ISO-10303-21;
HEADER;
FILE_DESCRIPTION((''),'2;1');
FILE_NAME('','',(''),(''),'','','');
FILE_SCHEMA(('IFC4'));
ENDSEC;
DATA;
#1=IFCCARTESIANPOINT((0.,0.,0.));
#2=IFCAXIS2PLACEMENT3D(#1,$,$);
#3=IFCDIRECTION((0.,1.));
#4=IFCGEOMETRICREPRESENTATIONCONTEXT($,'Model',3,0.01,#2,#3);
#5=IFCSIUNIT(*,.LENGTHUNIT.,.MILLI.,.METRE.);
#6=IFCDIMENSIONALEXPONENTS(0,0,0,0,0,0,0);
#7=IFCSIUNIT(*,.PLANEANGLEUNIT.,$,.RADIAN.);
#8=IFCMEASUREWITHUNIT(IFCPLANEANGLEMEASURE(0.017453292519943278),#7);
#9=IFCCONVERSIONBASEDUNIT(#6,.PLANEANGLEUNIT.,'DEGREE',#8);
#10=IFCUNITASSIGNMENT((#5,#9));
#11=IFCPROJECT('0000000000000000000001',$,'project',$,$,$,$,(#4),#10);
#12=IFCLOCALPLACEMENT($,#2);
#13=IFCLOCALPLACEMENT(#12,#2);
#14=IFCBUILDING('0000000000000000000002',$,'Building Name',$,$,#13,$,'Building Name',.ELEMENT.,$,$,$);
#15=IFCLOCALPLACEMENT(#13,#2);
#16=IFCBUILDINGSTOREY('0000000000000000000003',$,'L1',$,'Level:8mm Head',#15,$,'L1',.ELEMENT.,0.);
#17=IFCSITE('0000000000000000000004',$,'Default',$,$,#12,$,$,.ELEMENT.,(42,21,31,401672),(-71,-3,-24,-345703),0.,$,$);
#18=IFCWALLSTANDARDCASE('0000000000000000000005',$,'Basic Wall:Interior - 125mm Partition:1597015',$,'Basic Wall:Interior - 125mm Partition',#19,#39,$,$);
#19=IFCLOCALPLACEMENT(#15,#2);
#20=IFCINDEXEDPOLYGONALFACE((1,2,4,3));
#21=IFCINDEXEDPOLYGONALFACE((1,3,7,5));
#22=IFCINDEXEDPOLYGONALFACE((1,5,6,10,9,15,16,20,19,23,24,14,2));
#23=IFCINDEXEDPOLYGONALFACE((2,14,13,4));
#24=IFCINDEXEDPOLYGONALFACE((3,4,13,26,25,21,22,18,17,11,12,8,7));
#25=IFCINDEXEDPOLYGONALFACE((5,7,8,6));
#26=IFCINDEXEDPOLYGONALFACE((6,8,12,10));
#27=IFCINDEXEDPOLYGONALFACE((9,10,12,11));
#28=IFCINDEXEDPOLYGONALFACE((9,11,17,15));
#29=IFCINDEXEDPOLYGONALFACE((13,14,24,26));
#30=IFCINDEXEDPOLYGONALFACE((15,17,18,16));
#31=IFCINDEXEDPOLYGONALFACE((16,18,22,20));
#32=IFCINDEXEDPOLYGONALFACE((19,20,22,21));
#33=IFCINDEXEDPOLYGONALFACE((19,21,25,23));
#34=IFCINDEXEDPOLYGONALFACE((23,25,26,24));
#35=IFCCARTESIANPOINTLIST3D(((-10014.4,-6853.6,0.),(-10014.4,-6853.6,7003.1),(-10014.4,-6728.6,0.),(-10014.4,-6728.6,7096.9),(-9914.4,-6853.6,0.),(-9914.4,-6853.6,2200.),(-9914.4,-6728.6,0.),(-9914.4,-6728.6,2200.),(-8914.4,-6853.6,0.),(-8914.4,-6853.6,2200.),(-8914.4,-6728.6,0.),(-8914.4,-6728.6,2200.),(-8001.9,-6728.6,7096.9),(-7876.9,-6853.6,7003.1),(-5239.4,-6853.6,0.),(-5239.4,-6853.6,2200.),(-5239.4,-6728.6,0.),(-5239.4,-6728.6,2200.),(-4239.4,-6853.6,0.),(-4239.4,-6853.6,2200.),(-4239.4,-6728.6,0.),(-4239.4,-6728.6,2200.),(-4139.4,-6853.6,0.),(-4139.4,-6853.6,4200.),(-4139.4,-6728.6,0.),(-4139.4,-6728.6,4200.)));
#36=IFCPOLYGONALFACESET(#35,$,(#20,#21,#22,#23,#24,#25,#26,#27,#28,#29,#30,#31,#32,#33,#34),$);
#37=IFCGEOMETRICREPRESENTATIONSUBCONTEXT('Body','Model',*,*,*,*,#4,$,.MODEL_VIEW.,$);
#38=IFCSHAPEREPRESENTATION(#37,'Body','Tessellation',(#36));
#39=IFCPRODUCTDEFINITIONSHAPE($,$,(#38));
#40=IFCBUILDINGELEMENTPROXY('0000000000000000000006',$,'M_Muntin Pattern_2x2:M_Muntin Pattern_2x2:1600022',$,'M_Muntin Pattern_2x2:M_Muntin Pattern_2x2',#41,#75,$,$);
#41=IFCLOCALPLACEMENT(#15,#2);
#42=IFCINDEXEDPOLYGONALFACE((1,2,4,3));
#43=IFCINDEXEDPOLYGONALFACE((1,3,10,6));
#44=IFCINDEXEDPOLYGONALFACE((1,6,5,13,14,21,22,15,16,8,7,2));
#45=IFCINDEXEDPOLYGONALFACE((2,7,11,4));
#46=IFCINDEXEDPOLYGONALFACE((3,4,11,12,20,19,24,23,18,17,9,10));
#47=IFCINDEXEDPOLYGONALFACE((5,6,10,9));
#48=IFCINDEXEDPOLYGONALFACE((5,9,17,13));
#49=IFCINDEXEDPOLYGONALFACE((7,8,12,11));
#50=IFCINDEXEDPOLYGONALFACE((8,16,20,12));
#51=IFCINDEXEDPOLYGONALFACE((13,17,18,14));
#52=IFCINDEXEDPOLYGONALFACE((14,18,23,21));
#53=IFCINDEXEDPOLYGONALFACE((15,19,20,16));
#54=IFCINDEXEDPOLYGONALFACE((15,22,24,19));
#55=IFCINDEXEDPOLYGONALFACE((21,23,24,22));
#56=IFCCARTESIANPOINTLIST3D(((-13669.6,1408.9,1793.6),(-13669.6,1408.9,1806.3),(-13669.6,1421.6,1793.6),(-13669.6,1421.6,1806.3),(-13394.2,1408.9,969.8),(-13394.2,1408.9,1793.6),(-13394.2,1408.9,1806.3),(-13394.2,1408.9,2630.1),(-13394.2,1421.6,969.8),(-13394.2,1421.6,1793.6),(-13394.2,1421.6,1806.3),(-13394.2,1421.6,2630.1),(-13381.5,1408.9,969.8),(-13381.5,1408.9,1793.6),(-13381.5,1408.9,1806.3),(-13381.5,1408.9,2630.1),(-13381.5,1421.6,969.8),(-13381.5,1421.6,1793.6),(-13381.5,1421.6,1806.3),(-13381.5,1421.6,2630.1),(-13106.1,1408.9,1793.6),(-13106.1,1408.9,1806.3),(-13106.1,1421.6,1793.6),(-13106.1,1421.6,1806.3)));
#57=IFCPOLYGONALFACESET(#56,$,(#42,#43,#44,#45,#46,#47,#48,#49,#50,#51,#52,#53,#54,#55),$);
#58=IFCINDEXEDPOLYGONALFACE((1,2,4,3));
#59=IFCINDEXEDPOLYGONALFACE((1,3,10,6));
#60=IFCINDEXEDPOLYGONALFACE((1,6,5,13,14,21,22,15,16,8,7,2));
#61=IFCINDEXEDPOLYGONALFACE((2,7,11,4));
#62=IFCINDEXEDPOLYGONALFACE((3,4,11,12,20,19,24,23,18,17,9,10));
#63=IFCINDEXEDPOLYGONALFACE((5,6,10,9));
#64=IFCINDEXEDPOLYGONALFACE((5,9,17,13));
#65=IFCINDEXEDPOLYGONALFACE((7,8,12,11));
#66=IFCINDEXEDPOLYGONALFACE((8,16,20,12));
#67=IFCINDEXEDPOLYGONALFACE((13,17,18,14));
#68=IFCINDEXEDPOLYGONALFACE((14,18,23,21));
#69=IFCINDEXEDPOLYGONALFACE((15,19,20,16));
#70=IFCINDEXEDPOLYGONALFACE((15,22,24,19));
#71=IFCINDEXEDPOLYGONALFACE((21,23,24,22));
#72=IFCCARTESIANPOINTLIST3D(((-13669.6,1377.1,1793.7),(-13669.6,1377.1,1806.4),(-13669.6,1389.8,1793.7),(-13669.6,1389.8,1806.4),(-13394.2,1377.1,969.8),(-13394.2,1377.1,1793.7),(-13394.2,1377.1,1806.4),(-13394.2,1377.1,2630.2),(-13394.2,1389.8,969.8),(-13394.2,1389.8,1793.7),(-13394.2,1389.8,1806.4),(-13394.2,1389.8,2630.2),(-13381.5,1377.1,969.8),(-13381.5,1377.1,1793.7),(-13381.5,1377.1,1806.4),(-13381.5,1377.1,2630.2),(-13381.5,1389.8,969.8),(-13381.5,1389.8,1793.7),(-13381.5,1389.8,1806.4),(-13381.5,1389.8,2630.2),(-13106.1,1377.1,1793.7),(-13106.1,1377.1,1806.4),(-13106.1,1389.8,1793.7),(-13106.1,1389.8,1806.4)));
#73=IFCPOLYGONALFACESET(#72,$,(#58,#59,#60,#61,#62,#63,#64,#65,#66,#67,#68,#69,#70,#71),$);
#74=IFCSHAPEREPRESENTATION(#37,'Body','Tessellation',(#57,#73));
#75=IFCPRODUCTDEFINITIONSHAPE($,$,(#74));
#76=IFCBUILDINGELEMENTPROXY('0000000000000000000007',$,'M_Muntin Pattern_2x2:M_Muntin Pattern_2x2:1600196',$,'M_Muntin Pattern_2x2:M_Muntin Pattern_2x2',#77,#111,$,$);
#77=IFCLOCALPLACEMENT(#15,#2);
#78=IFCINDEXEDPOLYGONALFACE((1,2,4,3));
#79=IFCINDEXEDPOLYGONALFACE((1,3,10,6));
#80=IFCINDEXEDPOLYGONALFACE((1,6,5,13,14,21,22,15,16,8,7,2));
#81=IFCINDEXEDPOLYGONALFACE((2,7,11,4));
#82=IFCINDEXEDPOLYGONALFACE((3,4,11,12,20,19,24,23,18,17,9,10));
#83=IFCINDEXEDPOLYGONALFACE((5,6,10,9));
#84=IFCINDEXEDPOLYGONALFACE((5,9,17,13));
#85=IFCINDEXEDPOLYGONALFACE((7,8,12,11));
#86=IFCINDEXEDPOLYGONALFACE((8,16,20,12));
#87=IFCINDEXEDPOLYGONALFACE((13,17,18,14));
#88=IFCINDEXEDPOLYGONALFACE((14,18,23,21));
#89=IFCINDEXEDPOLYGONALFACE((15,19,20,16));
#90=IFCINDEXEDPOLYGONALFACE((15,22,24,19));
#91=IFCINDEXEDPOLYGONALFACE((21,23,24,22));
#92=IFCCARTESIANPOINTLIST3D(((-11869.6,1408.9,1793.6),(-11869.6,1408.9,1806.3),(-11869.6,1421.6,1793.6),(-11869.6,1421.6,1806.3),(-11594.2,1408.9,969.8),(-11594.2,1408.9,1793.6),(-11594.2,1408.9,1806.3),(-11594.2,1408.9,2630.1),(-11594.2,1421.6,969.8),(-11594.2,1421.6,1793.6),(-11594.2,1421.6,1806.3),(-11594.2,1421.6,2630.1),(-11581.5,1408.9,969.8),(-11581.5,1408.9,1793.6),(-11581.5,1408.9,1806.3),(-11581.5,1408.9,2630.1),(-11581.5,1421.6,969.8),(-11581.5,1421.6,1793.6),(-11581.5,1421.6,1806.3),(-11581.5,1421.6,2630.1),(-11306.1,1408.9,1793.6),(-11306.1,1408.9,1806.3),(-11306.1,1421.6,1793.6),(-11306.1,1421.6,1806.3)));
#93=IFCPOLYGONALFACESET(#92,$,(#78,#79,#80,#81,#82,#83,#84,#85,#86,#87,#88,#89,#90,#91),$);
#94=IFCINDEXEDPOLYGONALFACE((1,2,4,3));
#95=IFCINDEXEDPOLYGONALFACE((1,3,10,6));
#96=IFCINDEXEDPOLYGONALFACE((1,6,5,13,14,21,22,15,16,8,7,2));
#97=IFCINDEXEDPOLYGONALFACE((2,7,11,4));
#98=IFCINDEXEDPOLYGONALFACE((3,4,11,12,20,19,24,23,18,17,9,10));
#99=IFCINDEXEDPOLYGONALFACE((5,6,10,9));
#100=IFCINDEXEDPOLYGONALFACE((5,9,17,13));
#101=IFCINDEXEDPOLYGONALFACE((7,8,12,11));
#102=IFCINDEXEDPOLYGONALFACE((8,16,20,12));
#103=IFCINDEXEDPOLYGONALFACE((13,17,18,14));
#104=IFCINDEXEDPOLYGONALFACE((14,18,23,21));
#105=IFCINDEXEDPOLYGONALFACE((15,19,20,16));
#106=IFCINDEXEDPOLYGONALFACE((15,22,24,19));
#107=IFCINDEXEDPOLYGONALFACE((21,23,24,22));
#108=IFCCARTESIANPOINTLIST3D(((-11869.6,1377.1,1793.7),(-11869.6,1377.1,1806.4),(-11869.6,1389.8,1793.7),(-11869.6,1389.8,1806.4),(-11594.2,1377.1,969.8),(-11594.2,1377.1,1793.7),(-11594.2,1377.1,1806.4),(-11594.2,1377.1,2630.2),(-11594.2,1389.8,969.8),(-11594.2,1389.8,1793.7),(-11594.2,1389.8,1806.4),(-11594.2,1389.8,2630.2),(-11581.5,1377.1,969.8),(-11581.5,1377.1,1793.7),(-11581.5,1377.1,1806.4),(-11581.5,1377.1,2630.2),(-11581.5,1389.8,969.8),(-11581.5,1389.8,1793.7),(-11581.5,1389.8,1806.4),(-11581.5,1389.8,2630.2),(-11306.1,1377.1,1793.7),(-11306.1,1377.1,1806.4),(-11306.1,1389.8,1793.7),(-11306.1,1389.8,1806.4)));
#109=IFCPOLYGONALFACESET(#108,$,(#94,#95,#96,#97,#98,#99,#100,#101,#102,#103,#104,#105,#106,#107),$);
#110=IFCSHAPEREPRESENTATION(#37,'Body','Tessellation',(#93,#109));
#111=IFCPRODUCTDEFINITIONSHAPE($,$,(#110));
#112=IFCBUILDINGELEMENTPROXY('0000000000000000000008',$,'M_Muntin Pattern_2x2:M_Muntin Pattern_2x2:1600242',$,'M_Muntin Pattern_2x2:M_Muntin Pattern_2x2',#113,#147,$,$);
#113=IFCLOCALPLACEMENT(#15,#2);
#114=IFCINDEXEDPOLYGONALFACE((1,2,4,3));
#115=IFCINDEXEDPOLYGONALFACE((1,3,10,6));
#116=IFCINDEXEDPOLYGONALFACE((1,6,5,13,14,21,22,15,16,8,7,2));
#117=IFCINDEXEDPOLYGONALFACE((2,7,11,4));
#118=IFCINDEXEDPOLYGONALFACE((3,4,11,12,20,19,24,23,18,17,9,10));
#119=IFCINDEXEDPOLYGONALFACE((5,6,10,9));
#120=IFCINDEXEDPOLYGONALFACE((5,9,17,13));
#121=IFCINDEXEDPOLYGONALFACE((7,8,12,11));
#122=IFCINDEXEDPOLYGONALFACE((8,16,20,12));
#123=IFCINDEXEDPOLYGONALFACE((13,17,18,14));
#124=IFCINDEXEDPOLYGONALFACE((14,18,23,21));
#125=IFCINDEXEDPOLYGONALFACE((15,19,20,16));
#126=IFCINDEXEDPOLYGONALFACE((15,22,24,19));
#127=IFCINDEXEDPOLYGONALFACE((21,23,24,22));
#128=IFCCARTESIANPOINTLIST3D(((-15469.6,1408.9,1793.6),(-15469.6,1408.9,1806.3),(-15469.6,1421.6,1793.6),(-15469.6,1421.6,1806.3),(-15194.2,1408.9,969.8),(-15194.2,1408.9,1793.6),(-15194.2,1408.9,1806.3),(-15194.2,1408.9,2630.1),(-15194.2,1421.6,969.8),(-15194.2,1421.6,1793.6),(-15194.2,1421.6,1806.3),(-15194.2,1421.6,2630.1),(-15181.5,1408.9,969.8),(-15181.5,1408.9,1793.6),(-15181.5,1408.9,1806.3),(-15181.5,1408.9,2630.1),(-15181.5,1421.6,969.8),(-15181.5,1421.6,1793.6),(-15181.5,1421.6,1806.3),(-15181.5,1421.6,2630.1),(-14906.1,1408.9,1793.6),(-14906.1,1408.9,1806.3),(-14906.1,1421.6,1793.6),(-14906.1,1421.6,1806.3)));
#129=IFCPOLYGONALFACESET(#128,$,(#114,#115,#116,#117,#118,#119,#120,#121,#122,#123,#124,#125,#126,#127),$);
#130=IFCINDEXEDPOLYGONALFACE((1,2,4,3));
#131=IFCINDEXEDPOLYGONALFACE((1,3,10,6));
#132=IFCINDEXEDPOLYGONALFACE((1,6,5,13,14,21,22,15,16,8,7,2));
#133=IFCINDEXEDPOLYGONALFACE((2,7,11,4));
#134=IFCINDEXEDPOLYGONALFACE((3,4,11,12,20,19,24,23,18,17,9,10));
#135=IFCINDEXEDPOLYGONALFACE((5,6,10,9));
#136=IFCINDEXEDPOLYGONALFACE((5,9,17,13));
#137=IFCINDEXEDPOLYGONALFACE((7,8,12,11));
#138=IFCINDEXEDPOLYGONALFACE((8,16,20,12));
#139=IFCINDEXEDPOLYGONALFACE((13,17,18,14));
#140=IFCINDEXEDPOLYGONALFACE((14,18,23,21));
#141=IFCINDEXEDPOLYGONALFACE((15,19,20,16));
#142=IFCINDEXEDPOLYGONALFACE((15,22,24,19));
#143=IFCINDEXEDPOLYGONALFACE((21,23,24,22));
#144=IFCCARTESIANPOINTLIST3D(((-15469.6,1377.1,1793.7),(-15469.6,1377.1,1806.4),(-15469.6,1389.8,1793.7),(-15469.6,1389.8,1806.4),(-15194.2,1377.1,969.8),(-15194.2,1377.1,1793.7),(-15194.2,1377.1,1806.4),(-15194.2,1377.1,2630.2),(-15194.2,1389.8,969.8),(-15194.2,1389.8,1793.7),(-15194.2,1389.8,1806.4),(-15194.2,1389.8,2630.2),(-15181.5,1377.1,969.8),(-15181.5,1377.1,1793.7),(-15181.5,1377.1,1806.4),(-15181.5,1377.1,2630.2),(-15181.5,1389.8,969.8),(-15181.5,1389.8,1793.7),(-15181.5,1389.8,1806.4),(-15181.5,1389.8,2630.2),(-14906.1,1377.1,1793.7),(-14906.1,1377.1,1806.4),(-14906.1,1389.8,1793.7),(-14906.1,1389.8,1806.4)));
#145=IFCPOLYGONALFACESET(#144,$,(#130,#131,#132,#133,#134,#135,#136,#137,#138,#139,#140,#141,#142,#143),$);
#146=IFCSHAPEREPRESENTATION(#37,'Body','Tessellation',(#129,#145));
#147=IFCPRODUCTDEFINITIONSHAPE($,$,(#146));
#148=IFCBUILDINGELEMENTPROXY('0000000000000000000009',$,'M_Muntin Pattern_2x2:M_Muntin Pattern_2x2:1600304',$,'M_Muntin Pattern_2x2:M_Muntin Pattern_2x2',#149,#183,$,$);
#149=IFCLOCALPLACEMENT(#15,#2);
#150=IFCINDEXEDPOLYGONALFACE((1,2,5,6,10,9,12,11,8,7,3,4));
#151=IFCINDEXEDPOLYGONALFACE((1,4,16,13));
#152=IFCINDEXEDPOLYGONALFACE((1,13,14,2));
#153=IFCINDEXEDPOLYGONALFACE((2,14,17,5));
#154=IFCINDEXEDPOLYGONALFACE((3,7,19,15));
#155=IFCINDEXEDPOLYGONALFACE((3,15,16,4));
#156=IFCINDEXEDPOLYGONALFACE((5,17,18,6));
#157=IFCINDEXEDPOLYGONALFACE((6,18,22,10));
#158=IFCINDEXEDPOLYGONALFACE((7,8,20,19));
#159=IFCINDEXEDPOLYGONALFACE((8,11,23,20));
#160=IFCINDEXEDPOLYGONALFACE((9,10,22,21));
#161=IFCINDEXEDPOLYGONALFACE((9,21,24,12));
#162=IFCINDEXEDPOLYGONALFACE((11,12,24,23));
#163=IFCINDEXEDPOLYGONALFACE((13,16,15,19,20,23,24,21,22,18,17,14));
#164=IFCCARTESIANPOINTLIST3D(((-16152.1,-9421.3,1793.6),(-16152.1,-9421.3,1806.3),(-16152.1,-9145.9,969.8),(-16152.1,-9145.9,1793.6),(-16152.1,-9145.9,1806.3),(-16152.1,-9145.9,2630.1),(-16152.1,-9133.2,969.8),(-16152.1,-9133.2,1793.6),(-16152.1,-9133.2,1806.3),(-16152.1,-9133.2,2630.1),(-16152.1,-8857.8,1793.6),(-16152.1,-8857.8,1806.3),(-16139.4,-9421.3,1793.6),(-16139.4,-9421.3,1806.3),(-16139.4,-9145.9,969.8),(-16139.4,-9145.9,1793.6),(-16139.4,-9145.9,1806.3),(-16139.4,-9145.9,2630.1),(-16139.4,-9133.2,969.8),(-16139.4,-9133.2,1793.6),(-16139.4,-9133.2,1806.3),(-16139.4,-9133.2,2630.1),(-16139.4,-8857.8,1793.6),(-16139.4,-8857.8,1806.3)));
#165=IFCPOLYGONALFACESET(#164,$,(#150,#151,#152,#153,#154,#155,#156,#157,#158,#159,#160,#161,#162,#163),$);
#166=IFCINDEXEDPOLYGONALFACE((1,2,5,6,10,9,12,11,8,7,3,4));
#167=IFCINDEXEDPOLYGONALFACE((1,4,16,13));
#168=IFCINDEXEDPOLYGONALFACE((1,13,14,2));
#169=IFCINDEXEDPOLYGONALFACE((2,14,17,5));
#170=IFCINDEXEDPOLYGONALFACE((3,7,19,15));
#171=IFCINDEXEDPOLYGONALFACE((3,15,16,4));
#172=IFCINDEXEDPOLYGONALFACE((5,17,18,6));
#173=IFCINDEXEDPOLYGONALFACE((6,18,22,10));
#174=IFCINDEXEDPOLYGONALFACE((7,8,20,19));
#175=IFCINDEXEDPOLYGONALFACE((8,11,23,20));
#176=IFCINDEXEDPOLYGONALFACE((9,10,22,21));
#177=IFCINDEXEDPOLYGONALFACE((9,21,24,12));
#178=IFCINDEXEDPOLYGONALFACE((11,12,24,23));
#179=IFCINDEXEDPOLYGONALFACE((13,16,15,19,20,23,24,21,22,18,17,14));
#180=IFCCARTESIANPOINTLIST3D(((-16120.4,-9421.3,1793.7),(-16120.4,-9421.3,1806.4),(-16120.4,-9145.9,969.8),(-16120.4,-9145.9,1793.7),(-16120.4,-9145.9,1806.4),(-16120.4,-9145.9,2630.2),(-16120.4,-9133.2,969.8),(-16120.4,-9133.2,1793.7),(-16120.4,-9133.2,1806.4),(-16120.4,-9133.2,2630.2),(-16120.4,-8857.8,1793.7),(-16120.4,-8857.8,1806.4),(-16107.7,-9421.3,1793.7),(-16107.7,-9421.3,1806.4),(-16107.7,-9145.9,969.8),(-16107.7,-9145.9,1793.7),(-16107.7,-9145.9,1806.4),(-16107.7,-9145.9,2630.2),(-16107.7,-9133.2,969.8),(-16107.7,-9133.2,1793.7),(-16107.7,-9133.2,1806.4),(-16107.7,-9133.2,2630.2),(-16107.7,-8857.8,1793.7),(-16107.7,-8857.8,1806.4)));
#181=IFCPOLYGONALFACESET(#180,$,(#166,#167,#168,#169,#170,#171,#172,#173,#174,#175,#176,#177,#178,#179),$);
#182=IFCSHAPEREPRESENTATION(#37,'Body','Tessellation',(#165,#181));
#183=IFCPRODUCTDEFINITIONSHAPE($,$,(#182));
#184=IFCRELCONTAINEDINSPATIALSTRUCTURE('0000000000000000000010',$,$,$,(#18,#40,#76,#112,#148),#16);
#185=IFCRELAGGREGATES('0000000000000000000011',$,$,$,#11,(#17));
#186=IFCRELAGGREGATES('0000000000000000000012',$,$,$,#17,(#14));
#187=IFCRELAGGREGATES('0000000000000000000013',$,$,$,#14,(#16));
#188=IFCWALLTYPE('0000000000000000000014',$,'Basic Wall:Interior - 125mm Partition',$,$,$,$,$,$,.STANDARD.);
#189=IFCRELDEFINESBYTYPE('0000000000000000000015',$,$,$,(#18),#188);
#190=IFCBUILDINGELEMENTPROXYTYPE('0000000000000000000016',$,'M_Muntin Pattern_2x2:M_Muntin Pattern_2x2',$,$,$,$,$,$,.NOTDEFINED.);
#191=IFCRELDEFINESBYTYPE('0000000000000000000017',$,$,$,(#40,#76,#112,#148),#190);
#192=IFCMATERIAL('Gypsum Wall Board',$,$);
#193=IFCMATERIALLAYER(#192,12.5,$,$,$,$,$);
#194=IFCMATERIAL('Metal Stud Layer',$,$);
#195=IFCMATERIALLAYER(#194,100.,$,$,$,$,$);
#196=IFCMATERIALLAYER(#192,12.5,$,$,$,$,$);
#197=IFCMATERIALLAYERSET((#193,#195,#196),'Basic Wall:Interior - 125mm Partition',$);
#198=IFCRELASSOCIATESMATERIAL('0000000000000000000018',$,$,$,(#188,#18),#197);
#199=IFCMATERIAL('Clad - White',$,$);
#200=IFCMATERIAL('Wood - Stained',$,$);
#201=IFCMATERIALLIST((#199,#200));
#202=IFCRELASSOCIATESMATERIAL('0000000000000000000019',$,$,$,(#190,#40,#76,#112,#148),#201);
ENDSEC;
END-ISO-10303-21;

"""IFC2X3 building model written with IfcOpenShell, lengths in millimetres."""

from ifc_helpers import new_model, entity, si_unit, converted_unit, direction, frame, frame_2d, origin, place, context, subcontext, project, spatial, polyline, rectangle, outline, extrude, clip, bounded_halfspace, source, transform, mapped, material, material_list, layer, layer_set, layer_usage, type_object, type_shapes, element, save


model = new_model("IFC2X3")

# Units and contexts
model_context = context("Model", 3, precision=0.01, world=origin(), true_north=direction((0.0, 1.0)))
body_context = subcontext(model_context, "Body", "Model", "MODEL_VIEW")
ifc_project = project(units=[si_unit("LENGTHUNIT", "METRE", prefix="MILLI"), converted_unit("PLANEANGLEUNIT", "DEGREE", entity("IfcPlaneAngleMeasure", 0.017453292519943278), si_unit("PLANEANGLEUNIT", "RADIAN"), dimensions=[0, 0, 0, 0, 0, 0, 0])], contexts=[model_context])

# Site, building, storey
site_placement = place(None, origin())
site = spatial("IfcSite", under=ifc_project, at=site_placement, Name="Default", CompositionType="ELEMENT", RefLatitude=(42, 21, 31, 401672), RefLongitude=(-71, -3, -24, -345703), RefElevation=0.0)
building_placement = place(site_placement, origin())
building = spatial("IfcBuilding", under=site, at=building_placement, Name="Building Name", LongName="Building Name", CompositionType="ELEMENT")
storey_placement = place(building_placement, origin())
storey = spatial("IfcBuildingStorey", under=building, at=storey_placement, Name="L1", ObjectType="Level:8mm Head", LongName="L1", CompositionType="ELEMENT", Elevation=0.0)

# Shared definitions
ifc_material_1 = material(Name="Gypsum Wall Board")
ifc_layer_1 = layer(ifc_material_1, 12.5)
ifc_material_2 = material(Name="Metal Stud Layer")
ifc_layer_2 = layer(ifc_material_2, 100.0)
ifc_layer_3 = layer(ifc_material_1, 12.5)
ifc_layer_set_1 = layer_set([ifc_layer_1, ifc_layer_2, ifc_layer_3], Name="Basic Wall:Interior - 125mm Partition")
ifc_layer_usage_1 = layer_usage(ifc_layer_set_1, "AXIS2", "NEGATIVE", 62.5)
wall_type_1 = type_object("IfcWallType", Name="Basic Wall:Interior - 125mm Partition", PredefinedType="STANDARD", material=ifc_layer_set_1)

# Wall, openings
wall_1_placement = place(storey_placement, frame((-10014.4, -6791.1, 0.0)))
wall_1 = element("IfcWallStandardCase", 1, at=wall_1_placement, inside=storey, type_object=wall_type_1, material=ifc_layer_usage_1, Name="Basic Wall:Interior - 125mm Partition:1597015", ObjectType="Basic Wall:Interior - 125mm Partition", context=body_context, shape_type="Clipping", body=[
    clip(clip(extrude(rectangle(XDim=5875.0, YDim=125.0, at=frame_2d((2937.5, 0.0), x_axis=(-1.0, 0.0))), origin(), (0.0, 0.0, 1.0), 7096.9), bounded_halfspace(frame((0.0, 62.5, 7096.9), z_axis=(0.0, -0.6, 0.8), x_axis=(1.0, 0.0, 0.0)), False, frame((0.0, 62.5, 7096.9)), polyline([(0.0, 0.0), (0.0, -125.0), (2137.5, -125.0), (2012.5, 0.0), (0.0, 0.0)]))), bounded_halfspace(frame((5875.0, -62.5, 4200.0), z_axis=(0.6, 0.0, 0.8), x_axis=(0.0, 1.0, 0.0)), False, frame((5875.0, -62.5, 4200.0)), polyline([(0.0, 0.0), (0.0, 125.0), (-3862.5, 125.0), (-3737.5, 0.0), (-2962.5, 0.0), (-2837.5, 0.0), (0.0, 0.0)]))),
])
opening_1_placement = place(wall_1_placement, frame((5775.0, 62.5, 0.0)))
element("IfcOpeningElement", 2, at=opening_1_placement, cuts=wall_1, ObjectType="Opening", context=body_context, shape_type="SweptSolid", body=[
    extrude(rectangle(XDim=2200.0, YDim=1000.0, at=frame_2d((1100.0, 500.0), x_axis=(1.0, 0.0))), frame((0.0, 0.0, 0.0), z_axis=(0.0, -1.0, 0.0), x_axis=(0.0, 0.0, 1.0)), (0.0, 0.0, 1.0), 125.0),
])
opening_2_placement = place(wall_1_placement, frame((1100.0, 62.5, 0.0)))
element("IfcOpeningElement", 3, at=opening_2_placement, cuts=wall_1, ObjectType="Opening", context=body_context, shape_type="SweptSolid", body=[
    extrude(rectangle(XDim=2200.0, YDim=1000.0, at=frame_2d((1100.0, 500.0), x_axis=(1.0, 0.0))), frame((0.0, 0.0, 0.0), z_axis=(0.0, -1.0, 0.0), x_axis=(0.0, 0.0, 1.0)), (0.0, 0.0, 1.0), 125.0),
])

# Building element proxies
ifc_material_3 = material(Name="Clad - White")
ifc_material_4 = material(Name="Wood - Stained")
ifc_material_list = material_list([ifc_material_3, ifc_material_4])
building_element_proxy_type_1 = type_object("IfcBuildingElementProxyType", Name="M_Muntin Pattern_2x2:M_Muntin Pattern_2x2", PredefinedType="NOTDEFINED", material=ifc_material_list)
shared_shape_1 = source(origin(), body_context, "Body", "SweptSolid", [
    extrude(outline(polyline([(6.4, -6.4), (830.1, -6.4), (830.1, 6.3), (6.4, 6.3), (6.4, 281.7), (-6.3, 281.7), (-6.3, 6.3), (-830.2, 6.3), (-830.2, -6.4), (-6.3, -6.4), (-6.3, -281.7), (6.4, -281.7), (6.4, -6.4)])), frame((0.0, 9.5, 830.1), z_axis=(0.0, 1.0, 0.0), x_axis=(0.0, 0.0, 1.0)), (0.0, 0.0, 1.0), 12.7),
    extrude(outline(polyline([(6.4, -6.4), (830.2, -6.4), (830.2, 6.3), (6.4, 6.3), (6.4, 281.7), (-6.3, 281.7), (-6.3, 6.3), (-830.2, 6.3), (-830.2, -6.4), (-6.3, -6.4), (-6.3, -281.7), (6.4, -281.7), (6.4, -6.4)])), frame((0.0, -22.2, 830.2), z_axis=(0.0, 1.0, 0.0), x_axis=(0.0, 0.0, 1.0)), (0.0, 0.0, 1.0), 12.7),
])
type_shapes(building_element_proxy_type_1, [shared_shape_1])
for number, where, name in (
    (4, (-13387.9, 1399.4, 969.8), "M_Muntin Pattern_2x2:M_Muntin Pattern_2x2:1600022"),
    (5, (-11587.9, 1399.4, 969.8), "M_Muntin Pattern_2x2:M_Muntin Pattern_2x2:1600196"),
    (6, (-15187.9, 1399.4, 969.8), "M_Muntin Pattern_2x2:M_Muntin Pattern_2x2:1600242"),
):
    element("IfcBuildingElementProxy", number, at=place(storey_placement, frame(where)), inside=storey, type_object=building_element_proxy_type_1, material=ifc_material_list, Name=name, ObjectType="M_Muntin Pattern_2x2:M_Muntin Pattern_2x2", context=body_context, shape_type="MappedRepresentation", body=[
        mapped(shared_shape_1, transform((0.0, 0.0, 0.0), scale=1.0)),
    ])
proxy_placement = place(storey_placement, frame((-16129.9, -9139.5, 969.8), z_axis=(0.0, 0.0, 1.0), x_axis=(0.0, 1.0, 0.0)))
element("IfcBuildingElementProxy", 7, at=proxy_placement, inside=storey, type_object=building_element_proxy_type_1, material=ifc_material_list, Name="M_Muntin Pattern_2x2:M_Muntin Pattern_2x2:1600304", ObjectType="M_Muntin Pattern_2x2:M_Muntin Pattern_2x2", context=body_context, shape_type="MappedRepresentation", body=[
    mapped(shared_shape_1, transform((0.0, 0.0, 0.0), scale=1.0)),
])

save(model, "model.ifc")
